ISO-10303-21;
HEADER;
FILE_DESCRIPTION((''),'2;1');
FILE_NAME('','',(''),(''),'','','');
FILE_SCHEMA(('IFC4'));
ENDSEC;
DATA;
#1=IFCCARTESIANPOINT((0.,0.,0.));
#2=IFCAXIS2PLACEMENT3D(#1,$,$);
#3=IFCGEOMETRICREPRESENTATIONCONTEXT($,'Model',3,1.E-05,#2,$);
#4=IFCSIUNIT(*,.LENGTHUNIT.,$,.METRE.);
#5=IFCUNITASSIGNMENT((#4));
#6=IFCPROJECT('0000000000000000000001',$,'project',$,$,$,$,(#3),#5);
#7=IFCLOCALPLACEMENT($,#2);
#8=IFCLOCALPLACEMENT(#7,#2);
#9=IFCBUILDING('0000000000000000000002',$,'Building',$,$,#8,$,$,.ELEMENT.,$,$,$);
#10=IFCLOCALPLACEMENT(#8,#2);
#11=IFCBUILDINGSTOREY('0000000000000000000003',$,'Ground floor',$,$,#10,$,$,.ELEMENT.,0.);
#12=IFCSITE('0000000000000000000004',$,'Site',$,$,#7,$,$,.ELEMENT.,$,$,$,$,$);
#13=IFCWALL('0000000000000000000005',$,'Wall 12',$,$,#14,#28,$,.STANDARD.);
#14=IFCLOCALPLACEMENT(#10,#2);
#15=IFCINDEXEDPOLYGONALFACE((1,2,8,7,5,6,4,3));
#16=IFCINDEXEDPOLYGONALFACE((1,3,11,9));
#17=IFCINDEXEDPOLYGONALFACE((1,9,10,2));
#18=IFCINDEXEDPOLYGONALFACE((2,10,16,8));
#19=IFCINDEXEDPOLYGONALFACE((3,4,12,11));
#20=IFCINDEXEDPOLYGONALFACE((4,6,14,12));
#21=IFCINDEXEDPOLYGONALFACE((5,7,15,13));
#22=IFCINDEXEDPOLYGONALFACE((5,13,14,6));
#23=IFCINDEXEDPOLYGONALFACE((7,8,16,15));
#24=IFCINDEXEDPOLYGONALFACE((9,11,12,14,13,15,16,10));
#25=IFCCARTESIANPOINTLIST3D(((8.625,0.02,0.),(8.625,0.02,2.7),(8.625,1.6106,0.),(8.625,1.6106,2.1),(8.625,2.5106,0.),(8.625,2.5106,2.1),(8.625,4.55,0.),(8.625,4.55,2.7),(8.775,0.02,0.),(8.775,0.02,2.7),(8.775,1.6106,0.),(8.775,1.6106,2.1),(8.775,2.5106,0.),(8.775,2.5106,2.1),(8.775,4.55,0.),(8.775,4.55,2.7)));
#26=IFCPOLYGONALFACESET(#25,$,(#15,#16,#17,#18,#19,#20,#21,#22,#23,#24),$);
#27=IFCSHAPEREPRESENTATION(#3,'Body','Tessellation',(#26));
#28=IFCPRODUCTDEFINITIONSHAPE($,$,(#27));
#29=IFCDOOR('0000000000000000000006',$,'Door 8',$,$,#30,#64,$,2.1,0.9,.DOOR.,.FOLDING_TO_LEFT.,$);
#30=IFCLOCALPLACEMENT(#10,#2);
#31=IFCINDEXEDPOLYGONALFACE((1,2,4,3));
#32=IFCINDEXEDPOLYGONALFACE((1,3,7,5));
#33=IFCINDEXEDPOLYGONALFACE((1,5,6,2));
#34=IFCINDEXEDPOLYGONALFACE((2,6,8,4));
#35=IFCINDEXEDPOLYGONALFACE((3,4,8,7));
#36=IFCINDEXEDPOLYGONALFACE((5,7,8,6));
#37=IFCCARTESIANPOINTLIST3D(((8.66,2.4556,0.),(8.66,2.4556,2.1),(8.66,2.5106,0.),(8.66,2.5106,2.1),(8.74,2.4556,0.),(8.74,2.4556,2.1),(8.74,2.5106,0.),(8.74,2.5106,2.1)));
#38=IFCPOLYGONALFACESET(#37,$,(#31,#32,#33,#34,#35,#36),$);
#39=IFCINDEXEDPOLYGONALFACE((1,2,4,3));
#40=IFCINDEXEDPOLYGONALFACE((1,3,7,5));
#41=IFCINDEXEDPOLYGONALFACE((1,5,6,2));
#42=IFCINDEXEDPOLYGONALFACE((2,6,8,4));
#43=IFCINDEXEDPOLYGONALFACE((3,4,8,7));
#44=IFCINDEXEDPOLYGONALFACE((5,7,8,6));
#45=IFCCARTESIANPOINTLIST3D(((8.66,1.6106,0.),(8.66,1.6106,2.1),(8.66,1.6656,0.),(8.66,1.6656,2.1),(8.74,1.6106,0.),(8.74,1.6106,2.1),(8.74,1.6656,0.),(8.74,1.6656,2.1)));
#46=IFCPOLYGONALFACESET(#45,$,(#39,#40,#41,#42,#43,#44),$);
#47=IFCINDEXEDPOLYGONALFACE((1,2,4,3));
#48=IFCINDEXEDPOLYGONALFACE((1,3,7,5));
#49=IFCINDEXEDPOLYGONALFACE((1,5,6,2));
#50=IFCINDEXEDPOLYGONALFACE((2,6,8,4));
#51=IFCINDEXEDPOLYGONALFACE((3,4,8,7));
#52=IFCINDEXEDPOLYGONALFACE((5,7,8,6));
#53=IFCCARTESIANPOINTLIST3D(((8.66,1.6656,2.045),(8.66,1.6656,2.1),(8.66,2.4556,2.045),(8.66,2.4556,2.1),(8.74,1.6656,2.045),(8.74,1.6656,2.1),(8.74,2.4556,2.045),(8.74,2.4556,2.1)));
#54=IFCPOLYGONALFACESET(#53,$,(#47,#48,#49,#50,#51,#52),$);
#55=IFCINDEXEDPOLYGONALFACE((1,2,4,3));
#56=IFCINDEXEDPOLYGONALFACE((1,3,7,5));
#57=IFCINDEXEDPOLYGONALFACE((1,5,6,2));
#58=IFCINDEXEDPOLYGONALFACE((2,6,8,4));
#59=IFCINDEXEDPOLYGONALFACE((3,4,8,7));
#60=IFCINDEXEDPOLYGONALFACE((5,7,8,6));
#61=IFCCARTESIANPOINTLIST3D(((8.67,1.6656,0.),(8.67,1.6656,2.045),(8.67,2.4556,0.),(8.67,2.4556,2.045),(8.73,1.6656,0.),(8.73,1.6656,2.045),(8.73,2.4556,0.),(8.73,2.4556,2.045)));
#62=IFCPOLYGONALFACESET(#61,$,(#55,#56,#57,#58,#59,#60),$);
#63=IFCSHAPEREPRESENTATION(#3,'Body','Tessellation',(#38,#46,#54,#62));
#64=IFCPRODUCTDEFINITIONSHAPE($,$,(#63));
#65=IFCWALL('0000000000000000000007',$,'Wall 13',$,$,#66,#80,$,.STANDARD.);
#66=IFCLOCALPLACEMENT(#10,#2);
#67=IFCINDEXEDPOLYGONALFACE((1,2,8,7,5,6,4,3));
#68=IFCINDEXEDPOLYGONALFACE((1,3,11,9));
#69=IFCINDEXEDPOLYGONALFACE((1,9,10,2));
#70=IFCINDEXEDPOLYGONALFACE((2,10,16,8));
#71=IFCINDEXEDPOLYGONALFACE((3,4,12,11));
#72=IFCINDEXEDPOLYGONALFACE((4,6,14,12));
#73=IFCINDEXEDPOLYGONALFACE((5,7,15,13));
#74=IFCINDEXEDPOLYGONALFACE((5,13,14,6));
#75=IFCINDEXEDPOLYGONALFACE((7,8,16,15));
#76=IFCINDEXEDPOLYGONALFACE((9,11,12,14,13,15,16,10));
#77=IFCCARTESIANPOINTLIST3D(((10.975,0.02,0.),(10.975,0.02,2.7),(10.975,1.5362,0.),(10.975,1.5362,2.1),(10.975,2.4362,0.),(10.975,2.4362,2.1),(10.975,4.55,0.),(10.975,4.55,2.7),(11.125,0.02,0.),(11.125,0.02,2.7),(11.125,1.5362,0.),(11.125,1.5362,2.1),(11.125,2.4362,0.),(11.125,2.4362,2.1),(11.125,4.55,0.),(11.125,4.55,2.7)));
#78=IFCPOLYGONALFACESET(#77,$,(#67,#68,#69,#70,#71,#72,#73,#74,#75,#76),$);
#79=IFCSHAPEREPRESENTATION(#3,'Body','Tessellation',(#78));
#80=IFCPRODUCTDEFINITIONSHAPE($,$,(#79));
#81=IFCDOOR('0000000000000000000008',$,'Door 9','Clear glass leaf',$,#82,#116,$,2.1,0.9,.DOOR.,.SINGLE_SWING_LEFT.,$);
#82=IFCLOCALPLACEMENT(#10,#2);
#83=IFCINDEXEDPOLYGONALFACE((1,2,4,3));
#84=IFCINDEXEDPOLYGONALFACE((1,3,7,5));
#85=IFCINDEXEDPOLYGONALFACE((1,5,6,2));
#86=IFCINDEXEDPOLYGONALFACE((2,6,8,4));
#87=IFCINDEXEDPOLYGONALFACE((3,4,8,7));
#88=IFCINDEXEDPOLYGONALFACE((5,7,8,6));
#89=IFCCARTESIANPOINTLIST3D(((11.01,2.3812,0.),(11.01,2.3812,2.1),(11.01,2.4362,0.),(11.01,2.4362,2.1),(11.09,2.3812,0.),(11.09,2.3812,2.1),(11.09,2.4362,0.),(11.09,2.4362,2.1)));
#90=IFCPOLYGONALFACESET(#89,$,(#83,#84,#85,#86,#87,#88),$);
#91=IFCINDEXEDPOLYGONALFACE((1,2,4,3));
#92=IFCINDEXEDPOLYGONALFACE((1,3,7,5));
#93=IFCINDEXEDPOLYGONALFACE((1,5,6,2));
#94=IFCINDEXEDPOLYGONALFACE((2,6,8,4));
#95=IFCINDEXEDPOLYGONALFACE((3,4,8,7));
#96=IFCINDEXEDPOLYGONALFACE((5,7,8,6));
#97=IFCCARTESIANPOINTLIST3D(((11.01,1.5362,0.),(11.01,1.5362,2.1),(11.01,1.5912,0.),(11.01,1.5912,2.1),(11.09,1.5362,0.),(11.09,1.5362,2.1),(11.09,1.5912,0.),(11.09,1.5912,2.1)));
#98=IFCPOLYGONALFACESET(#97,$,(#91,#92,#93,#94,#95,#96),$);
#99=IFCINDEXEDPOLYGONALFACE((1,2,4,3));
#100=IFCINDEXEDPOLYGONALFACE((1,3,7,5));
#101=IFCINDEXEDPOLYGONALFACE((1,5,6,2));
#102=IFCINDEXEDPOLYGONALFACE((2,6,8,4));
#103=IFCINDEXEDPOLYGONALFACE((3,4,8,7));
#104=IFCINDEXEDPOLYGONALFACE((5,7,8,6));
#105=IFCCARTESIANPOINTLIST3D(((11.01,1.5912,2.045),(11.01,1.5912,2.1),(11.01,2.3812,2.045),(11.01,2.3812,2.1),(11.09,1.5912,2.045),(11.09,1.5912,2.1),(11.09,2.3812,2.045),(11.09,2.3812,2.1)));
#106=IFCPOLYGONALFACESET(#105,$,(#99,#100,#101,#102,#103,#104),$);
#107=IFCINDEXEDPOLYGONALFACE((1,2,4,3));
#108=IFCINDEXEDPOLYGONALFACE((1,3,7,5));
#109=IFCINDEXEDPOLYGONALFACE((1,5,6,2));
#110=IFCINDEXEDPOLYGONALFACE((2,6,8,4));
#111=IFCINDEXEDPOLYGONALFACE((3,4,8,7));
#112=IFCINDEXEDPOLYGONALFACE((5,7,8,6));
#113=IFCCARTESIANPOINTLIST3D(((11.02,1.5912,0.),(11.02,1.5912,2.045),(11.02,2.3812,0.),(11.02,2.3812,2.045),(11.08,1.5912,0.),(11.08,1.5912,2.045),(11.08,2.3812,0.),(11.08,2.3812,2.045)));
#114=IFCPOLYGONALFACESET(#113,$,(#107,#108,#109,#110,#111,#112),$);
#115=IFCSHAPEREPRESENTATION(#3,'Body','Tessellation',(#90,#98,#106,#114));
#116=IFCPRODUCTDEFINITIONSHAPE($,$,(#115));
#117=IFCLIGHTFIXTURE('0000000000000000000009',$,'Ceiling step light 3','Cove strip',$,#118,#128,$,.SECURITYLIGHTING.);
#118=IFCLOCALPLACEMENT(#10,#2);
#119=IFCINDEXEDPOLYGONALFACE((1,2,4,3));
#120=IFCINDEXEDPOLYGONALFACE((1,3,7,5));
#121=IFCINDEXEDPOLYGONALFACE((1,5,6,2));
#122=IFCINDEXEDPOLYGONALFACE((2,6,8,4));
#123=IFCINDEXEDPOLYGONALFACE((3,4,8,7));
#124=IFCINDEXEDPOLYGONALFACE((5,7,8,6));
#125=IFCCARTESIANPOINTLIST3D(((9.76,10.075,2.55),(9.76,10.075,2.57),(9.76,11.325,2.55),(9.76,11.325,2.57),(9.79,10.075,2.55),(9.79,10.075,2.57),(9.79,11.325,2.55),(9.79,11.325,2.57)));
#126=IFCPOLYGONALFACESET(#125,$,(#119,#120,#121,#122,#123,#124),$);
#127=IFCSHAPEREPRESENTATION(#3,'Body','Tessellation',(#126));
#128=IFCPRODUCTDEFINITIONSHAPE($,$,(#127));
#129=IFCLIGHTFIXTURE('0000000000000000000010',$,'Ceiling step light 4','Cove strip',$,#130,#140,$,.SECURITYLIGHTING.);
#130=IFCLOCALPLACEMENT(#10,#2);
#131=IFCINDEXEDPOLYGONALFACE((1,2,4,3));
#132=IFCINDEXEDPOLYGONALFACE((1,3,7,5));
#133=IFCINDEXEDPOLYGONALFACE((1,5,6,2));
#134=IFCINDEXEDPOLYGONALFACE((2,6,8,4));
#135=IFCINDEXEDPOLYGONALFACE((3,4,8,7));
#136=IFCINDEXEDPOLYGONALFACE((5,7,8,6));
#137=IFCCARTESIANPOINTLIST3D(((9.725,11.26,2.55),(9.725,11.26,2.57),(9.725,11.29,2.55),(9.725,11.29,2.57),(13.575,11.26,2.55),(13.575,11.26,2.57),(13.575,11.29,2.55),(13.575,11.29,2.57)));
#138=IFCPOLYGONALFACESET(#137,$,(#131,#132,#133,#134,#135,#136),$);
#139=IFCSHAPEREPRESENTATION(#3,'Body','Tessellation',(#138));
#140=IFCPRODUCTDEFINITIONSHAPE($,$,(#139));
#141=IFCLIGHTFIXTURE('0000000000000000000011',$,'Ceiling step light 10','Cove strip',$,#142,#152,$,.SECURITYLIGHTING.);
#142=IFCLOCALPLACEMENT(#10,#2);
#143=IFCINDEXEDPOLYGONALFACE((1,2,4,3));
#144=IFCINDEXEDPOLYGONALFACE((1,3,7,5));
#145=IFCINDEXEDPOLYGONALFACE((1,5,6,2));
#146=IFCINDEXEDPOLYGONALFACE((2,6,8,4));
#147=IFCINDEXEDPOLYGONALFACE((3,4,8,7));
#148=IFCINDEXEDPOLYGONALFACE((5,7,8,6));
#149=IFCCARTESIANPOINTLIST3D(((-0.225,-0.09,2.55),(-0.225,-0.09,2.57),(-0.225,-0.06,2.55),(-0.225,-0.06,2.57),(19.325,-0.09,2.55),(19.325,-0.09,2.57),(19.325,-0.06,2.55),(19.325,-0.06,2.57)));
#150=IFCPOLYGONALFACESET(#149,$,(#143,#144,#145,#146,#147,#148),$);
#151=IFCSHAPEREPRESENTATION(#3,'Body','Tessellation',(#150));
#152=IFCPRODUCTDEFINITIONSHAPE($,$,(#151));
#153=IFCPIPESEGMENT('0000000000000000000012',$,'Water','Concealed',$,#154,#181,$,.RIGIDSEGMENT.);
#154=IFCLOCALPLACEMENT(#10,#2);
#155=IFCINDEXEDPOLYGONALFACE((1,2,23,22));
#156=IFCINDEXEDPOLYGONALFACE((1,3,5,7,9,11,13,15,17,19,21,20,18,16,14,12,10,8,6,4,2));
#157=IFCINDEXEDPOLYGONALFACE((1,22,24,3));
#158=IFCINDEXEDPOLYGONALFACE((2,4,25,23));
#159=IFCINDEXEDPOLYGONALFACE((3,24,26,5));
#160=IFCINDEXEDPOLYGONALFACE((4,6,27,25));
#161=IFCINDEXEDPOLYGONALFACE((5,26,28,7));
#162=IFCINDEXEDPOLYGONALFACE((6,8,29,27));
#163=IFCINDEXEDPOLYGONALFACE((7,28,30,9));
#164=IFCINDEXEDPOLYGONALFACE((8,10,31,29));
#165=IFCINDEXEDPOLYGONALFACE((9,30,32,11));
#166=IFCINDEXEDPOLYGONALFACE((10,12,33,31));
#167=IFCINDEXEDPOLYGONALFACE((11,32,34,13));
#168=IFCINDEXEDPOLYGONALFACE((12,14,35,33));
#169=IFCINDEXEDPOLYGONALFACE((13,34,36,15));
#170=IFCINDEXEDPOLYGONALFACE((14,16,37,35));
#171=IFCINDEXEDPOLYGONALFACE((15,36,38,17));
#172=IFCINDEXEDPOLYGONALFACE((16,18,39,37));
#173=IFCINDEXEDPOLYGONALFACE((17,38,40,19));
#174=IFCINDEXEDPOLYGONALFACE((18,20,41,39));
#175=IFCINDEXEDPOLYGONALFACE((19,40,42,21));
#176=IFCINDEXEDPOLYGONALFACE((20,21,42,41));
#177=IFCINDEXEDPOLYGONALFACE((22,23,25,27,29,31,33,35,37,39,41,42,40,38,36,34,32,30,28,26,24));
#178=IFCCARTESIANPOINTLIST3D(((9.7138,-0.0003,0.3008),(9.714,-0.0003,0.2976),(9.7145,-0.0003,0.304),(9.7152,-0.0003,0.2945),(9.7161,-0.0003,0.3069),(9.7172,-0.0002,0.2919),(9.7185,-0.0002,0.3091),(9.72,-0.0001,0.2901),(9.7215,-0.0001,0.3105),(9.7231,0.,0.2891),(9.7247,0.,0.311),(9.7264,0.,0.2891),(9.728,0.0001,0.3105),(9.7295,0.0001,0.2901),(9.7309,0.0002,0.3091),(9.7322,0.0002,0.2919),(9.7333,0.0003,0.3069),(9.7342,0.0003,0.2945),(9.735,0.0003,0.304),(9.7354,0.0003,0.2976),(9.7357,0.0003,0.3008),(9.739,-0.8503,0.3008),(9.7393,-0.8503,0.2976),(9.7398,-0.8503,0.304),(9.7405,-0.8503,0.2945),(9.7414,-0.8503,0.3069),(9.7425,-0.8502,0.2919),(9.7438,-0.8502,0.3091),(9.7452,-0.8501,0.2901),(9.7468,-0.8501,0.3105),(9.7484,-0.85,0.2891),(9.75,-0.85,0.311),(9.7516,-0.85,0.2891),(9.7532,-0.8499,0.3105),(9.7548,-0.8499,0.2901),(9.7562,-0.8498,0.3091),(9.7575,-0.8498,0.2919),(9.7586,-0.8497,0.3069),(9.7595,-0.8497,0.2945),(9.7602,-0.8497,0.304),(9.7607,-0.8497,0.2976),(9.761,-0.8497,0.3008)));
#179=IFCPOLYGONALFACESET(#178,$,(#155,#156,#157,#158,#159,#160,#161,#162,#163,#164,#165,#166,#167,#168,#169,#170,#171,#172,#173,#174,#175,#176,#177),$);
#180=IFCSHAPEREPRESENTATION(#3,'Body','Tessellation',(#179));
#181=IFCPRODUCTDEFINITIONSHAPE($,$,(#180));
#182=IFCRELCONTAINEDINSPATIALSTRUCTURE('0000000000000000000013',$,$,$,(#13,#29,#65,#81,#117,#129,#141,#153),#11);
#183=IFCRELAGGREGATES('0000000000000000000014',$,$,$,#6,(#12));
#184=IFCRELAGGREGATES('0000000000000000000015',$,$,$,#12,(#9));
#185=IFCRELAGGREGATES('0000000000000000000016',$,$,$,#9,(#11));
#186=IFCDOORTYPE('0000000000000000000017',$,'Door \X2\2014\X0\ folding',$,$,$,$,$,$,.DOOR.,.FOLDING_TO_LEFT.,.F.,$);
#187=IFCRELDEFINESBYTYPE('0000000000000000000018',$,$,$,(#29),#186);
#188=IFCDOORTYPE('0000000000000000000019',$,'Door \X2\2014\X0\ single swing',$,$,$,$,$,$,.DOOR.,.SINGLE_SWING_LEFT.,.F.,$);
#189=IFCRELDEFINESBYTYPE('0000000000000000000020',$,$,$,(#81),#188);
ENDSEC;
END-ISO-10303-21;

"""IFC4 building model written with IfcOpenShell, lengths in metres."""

from ifc_helpers import new_model, si_unit, frame, frame_2d, origin, origin_2d, place, context, project, spatial, rectangle, circle, extrude, type_object, element, fill, save


model = new_model("IFC4")

# Units and contexts
model_context = context("Model", 3, precision=1e-05, world=origin())
ifc_project = project(units=[si_unit("LENGTHUNIT", "METRE")], contexts=[model_context])

# Site, building, storey
site_placement = place(None, origin())
site = spatial("IfcSite", under=ifc_project, at=site_placement, Name="Site", CompositionType="ELEMENT")
building_placement = place(site_placement, origin())
building = spatial("IfcBuilding", under=site, at=building_placement, Name="Building", CompositionType="ELEMENT")
storey_placement = place(building_placement, origin())
storey = spatial("IfcBuildingStorey", under=building, at=storey_placement, Name="Ground floor", CompositionType="ELEMENT", Elevation=0.0)

# Walls, openings, doors
wall_1_placement = place(storey_placement, frame((8.7, 4.55, 0.0), z_axis=(0.0, 0.0, 1.0), x_axis=(0.0, -1.0, 0.0)))
wall_1 = element("IfcWall", 1, at=wall_1_placement, inside=storey, Name="Wall 12", PredefinedType="STANDARD", context=model_context, shape_type="SweptSolid", body=[
    extrude(rectangle(XDim=4.53, YDim=0.15, at=frame_2d((2.265, 0.0))), origin(), (0.0, 0.0, 1.0), 2.7),
])
opening_1_placement = place(storey_placement, frame((8.7, 2.5106, 0.0), z_axis=(0.0, 0.0, 1.0), x_axis=(0.0, -1.0, 0.0)))
opening_1 = element("IfcOpeningElement", 2, at=opening_1_placement, cuts=wall_1, PredefinedType="OPENING", context=model_context, shape_type="SweptSolid", body=[
    extrude(rectangle(XDim=0.9, YDim=0.21, at=frame_2d((0.45, 0.0))), origin(), (0.0, 0.0, 1.0), 2.1),
])
door_type_1 = type_object("IfcDoorType", Name="Door — folding", OperationType="FOLDING_TO_LEFT", ParameterTakesPrecedence=False, PredefinedType="DOOR")
door_1_placement = place(storey_placement, frame((8.7, 2.5106, 0.0), z_axis=(0.0, 0.0, 1.0), x_axis=(0.0, -1.0, 0.0)))
door_1 = element("IfcDoor", 3, at=door_1_placement, inside=storey, type_object=door_type_1, Name="Door 8", OperationType="FOLDING_TO_LEFT", OverallHeight=2.1, OverallWidth=0.9, PredefinedType="DOOR", context=model_context, shape_type="SweptSolid", body=[
    extrude(rectangle(XDim=0.055, YDim=0.08, at=frame_2d((0.0275, 0.0))), origin(), (0.0, 0.0, 1.0), 2.1),
    extrude(rectangle(XDim=0.055, YDim=0.08, at=frame_2d((0.8725, 0.0))), origin(), (0.0, 0.0, 1.0), 2.1),
    extrude(rectangle(XDim=0.79, YDim=0.08, at=frame_2d((0.45, 0.0))), frame((0.0, 0.0, 2.045)), (0.0, 0.0, 1.0), 0.055),
    extrude(rectangle(XDim=0.79, YDim=0.06, at=frame_2d((0.45, 0.0))), origin(), (0.0, 0.0, 1.0), 2.045),
])
fill(opening_1, door_1)
wall_2_placement = place(storey_placement, frame((11.05, 4.55, 0.0), z_axis=(0.0, 0.0, 1.0), x_axis=(0.0, -1.0, 0.0)))
wall_2 = element("IfcWall", 4, at=wall_2_placement, inside=storey, Name="Wall 13", PredefinedType="STANDARD", context=model_context, shape_type="SweptSolid", body=[
    extrude(rectangle(XDim=4.53, YDim=0.15, at=frame_2d((2.265, 0.0))), origin(), (0.0, 0.0, 1.0), 2.7),
])
opening_2_placement = place(storey_placement, frame((11.05, 2.4362, 0.0), z_axis=(0.0, 0.0, 1.0), x_axis=(0.0, -1.0, 0.0)))
opening_2 = element("IfcOpeningElement", 5, at=opening_2_placement, cuts=wall_2, PredefinedType="OPENING", context=model_context, shape_type="SweptSolid", body=[
    extrude(rectangle(XDim=0.9, YDim=0.21, at=frame_2d((0.45, 0.0))), origin(), (0.0, 0.0, 1.0), 2.1),
])
door_type_2 = type_object("IfcDoorType", Name="Door — single swing", OperationType="SINGLE_SWING_LEFT", ParameterTakesPrecedence=False, PredefinedType="DOOR")
door_2_placement = place(storey_placement, frame((11.05, 2.4362, 0.0), z_axis=(0.0, 0.0, 1.0), x_axis=(0.0, -1.0, 0.0)))
door_2 = element("IfcDoor", 6, at=door_2_placement, inside=storey, type_object=door_type_2, Name="Door 9", Description="Clear glass leaf", OperationType="SINGLE_SWING_LEFT", OverallHeight=2.1, OverallWidth=0.9, PredefinedType="DOOR", context=model_context, shape_type="SweptSolid", body=[
    extrude(rectangle(XDim=0.055, YDim=0.08, at=frame_2d((0.0275, 0.0))), origin(), (0.0, 0.0, 1.0), 2.1),
    extrude(rectangle(XDim=0.055, YDim=0.08, at=frame_2d((0.8725, 0.0))), origin(), (0.0, 0.0, 1.0), 2.1),
    extrude(rectangle(XDim=0.79, YDim=0.08, at=frame_2d((0.45, 0.0))), frame((0.0, 0.0, 2.045)), (0.0, 0.0, 1.0), 0.055),
    extrude(rectangle(XDim=0.79, YDim=0.06, at=frame_2d((0.45, 0.0))), origin(), (0.0, 0.0, 1.0), 2.045),
])
fill(opening_2, door_2)

# Light fixtures
light_fixture_1_placement = place(storey_placement, frame((9.775, 10.7, 2.55), z_axis=(0.0, 0.0, 1.0), x_axis=(0.0, 1.0, 0.0)))
element("IfcLightFixture", 7, at=light_fixture_1_placement, inside=storey, Name="Ceiling step light 3", Description="Cove strip", PredefinedType="SECURITYLIGHTING", context=model_context, shape_type="SweptSolid", body=[
    extrude(rectangle(XDim=1.25, YDim=0.03, at=origin_2d()), origin(), (0.0, 0.0, 1.0), 0.02),
])
light_fixture_2_placement = place(storey_placement, frame((11.65, 11.275, 2.55), z_axis=(0.0, 0.0, 1.0), x_axis=(1.0, 0.0, 0.0)))
element("IfcLightFixture", 8, at=light_fixture_2_placement, inside=storey, Name="Ceiling step light 4", Description="Cove strip", PredefinedType="SECURITYLIGHTING", context=model_context, shape_type="SweptSolid", body=[
    extrude(rectangle(XDim=3.85, YDim=0.03, at=origin_2d()), origin(), (0.0, 0.0, 1.0), 0.02),
])
light_fixture_3_placement = place(storey_placement, frame((9.55, -0.075, 2.55), z_axis=(0.0, 0.0, 1.0), x_axis=(-1.0, 0.0, 0.0)))
element("IfcLightFixture", 9, at=light_fixture_3_placement, inside=storey, Name="Ceiling step light 10", Description="Cove strip", PredefinedType="SECURITYLIGHTING", context=model_context, shape_type="SweptSolid", body=[
    extrude(rectangle(XDim=19.55, YDim=0.03, at=origin_2d()), origin(), (0.0, 0.0, 1.0), 0.02),
])

# Pipe segment
pipe_segment_1_placement = place(storey_placement, frame((9.75, -0.85, 0.3), z_axis=(-0.02972, 0.999558, 0.0), x_axis=(0.0, 0.0, 1.0)))
element("IfcPipeSegment", 10, at=pipe_segment_1_placement, inside=storey, Name="Water", Description="Concealed", PredefinedType="RIGIDSEGMENT", context=model_context, shape_type="SweptSolid", body=[
    extrude(circle(Radius=0.011, at=origin_2d()), origin(), (0.0, 0.0, 1.0), 0.8504),
])

save(model, "model.ifc")
